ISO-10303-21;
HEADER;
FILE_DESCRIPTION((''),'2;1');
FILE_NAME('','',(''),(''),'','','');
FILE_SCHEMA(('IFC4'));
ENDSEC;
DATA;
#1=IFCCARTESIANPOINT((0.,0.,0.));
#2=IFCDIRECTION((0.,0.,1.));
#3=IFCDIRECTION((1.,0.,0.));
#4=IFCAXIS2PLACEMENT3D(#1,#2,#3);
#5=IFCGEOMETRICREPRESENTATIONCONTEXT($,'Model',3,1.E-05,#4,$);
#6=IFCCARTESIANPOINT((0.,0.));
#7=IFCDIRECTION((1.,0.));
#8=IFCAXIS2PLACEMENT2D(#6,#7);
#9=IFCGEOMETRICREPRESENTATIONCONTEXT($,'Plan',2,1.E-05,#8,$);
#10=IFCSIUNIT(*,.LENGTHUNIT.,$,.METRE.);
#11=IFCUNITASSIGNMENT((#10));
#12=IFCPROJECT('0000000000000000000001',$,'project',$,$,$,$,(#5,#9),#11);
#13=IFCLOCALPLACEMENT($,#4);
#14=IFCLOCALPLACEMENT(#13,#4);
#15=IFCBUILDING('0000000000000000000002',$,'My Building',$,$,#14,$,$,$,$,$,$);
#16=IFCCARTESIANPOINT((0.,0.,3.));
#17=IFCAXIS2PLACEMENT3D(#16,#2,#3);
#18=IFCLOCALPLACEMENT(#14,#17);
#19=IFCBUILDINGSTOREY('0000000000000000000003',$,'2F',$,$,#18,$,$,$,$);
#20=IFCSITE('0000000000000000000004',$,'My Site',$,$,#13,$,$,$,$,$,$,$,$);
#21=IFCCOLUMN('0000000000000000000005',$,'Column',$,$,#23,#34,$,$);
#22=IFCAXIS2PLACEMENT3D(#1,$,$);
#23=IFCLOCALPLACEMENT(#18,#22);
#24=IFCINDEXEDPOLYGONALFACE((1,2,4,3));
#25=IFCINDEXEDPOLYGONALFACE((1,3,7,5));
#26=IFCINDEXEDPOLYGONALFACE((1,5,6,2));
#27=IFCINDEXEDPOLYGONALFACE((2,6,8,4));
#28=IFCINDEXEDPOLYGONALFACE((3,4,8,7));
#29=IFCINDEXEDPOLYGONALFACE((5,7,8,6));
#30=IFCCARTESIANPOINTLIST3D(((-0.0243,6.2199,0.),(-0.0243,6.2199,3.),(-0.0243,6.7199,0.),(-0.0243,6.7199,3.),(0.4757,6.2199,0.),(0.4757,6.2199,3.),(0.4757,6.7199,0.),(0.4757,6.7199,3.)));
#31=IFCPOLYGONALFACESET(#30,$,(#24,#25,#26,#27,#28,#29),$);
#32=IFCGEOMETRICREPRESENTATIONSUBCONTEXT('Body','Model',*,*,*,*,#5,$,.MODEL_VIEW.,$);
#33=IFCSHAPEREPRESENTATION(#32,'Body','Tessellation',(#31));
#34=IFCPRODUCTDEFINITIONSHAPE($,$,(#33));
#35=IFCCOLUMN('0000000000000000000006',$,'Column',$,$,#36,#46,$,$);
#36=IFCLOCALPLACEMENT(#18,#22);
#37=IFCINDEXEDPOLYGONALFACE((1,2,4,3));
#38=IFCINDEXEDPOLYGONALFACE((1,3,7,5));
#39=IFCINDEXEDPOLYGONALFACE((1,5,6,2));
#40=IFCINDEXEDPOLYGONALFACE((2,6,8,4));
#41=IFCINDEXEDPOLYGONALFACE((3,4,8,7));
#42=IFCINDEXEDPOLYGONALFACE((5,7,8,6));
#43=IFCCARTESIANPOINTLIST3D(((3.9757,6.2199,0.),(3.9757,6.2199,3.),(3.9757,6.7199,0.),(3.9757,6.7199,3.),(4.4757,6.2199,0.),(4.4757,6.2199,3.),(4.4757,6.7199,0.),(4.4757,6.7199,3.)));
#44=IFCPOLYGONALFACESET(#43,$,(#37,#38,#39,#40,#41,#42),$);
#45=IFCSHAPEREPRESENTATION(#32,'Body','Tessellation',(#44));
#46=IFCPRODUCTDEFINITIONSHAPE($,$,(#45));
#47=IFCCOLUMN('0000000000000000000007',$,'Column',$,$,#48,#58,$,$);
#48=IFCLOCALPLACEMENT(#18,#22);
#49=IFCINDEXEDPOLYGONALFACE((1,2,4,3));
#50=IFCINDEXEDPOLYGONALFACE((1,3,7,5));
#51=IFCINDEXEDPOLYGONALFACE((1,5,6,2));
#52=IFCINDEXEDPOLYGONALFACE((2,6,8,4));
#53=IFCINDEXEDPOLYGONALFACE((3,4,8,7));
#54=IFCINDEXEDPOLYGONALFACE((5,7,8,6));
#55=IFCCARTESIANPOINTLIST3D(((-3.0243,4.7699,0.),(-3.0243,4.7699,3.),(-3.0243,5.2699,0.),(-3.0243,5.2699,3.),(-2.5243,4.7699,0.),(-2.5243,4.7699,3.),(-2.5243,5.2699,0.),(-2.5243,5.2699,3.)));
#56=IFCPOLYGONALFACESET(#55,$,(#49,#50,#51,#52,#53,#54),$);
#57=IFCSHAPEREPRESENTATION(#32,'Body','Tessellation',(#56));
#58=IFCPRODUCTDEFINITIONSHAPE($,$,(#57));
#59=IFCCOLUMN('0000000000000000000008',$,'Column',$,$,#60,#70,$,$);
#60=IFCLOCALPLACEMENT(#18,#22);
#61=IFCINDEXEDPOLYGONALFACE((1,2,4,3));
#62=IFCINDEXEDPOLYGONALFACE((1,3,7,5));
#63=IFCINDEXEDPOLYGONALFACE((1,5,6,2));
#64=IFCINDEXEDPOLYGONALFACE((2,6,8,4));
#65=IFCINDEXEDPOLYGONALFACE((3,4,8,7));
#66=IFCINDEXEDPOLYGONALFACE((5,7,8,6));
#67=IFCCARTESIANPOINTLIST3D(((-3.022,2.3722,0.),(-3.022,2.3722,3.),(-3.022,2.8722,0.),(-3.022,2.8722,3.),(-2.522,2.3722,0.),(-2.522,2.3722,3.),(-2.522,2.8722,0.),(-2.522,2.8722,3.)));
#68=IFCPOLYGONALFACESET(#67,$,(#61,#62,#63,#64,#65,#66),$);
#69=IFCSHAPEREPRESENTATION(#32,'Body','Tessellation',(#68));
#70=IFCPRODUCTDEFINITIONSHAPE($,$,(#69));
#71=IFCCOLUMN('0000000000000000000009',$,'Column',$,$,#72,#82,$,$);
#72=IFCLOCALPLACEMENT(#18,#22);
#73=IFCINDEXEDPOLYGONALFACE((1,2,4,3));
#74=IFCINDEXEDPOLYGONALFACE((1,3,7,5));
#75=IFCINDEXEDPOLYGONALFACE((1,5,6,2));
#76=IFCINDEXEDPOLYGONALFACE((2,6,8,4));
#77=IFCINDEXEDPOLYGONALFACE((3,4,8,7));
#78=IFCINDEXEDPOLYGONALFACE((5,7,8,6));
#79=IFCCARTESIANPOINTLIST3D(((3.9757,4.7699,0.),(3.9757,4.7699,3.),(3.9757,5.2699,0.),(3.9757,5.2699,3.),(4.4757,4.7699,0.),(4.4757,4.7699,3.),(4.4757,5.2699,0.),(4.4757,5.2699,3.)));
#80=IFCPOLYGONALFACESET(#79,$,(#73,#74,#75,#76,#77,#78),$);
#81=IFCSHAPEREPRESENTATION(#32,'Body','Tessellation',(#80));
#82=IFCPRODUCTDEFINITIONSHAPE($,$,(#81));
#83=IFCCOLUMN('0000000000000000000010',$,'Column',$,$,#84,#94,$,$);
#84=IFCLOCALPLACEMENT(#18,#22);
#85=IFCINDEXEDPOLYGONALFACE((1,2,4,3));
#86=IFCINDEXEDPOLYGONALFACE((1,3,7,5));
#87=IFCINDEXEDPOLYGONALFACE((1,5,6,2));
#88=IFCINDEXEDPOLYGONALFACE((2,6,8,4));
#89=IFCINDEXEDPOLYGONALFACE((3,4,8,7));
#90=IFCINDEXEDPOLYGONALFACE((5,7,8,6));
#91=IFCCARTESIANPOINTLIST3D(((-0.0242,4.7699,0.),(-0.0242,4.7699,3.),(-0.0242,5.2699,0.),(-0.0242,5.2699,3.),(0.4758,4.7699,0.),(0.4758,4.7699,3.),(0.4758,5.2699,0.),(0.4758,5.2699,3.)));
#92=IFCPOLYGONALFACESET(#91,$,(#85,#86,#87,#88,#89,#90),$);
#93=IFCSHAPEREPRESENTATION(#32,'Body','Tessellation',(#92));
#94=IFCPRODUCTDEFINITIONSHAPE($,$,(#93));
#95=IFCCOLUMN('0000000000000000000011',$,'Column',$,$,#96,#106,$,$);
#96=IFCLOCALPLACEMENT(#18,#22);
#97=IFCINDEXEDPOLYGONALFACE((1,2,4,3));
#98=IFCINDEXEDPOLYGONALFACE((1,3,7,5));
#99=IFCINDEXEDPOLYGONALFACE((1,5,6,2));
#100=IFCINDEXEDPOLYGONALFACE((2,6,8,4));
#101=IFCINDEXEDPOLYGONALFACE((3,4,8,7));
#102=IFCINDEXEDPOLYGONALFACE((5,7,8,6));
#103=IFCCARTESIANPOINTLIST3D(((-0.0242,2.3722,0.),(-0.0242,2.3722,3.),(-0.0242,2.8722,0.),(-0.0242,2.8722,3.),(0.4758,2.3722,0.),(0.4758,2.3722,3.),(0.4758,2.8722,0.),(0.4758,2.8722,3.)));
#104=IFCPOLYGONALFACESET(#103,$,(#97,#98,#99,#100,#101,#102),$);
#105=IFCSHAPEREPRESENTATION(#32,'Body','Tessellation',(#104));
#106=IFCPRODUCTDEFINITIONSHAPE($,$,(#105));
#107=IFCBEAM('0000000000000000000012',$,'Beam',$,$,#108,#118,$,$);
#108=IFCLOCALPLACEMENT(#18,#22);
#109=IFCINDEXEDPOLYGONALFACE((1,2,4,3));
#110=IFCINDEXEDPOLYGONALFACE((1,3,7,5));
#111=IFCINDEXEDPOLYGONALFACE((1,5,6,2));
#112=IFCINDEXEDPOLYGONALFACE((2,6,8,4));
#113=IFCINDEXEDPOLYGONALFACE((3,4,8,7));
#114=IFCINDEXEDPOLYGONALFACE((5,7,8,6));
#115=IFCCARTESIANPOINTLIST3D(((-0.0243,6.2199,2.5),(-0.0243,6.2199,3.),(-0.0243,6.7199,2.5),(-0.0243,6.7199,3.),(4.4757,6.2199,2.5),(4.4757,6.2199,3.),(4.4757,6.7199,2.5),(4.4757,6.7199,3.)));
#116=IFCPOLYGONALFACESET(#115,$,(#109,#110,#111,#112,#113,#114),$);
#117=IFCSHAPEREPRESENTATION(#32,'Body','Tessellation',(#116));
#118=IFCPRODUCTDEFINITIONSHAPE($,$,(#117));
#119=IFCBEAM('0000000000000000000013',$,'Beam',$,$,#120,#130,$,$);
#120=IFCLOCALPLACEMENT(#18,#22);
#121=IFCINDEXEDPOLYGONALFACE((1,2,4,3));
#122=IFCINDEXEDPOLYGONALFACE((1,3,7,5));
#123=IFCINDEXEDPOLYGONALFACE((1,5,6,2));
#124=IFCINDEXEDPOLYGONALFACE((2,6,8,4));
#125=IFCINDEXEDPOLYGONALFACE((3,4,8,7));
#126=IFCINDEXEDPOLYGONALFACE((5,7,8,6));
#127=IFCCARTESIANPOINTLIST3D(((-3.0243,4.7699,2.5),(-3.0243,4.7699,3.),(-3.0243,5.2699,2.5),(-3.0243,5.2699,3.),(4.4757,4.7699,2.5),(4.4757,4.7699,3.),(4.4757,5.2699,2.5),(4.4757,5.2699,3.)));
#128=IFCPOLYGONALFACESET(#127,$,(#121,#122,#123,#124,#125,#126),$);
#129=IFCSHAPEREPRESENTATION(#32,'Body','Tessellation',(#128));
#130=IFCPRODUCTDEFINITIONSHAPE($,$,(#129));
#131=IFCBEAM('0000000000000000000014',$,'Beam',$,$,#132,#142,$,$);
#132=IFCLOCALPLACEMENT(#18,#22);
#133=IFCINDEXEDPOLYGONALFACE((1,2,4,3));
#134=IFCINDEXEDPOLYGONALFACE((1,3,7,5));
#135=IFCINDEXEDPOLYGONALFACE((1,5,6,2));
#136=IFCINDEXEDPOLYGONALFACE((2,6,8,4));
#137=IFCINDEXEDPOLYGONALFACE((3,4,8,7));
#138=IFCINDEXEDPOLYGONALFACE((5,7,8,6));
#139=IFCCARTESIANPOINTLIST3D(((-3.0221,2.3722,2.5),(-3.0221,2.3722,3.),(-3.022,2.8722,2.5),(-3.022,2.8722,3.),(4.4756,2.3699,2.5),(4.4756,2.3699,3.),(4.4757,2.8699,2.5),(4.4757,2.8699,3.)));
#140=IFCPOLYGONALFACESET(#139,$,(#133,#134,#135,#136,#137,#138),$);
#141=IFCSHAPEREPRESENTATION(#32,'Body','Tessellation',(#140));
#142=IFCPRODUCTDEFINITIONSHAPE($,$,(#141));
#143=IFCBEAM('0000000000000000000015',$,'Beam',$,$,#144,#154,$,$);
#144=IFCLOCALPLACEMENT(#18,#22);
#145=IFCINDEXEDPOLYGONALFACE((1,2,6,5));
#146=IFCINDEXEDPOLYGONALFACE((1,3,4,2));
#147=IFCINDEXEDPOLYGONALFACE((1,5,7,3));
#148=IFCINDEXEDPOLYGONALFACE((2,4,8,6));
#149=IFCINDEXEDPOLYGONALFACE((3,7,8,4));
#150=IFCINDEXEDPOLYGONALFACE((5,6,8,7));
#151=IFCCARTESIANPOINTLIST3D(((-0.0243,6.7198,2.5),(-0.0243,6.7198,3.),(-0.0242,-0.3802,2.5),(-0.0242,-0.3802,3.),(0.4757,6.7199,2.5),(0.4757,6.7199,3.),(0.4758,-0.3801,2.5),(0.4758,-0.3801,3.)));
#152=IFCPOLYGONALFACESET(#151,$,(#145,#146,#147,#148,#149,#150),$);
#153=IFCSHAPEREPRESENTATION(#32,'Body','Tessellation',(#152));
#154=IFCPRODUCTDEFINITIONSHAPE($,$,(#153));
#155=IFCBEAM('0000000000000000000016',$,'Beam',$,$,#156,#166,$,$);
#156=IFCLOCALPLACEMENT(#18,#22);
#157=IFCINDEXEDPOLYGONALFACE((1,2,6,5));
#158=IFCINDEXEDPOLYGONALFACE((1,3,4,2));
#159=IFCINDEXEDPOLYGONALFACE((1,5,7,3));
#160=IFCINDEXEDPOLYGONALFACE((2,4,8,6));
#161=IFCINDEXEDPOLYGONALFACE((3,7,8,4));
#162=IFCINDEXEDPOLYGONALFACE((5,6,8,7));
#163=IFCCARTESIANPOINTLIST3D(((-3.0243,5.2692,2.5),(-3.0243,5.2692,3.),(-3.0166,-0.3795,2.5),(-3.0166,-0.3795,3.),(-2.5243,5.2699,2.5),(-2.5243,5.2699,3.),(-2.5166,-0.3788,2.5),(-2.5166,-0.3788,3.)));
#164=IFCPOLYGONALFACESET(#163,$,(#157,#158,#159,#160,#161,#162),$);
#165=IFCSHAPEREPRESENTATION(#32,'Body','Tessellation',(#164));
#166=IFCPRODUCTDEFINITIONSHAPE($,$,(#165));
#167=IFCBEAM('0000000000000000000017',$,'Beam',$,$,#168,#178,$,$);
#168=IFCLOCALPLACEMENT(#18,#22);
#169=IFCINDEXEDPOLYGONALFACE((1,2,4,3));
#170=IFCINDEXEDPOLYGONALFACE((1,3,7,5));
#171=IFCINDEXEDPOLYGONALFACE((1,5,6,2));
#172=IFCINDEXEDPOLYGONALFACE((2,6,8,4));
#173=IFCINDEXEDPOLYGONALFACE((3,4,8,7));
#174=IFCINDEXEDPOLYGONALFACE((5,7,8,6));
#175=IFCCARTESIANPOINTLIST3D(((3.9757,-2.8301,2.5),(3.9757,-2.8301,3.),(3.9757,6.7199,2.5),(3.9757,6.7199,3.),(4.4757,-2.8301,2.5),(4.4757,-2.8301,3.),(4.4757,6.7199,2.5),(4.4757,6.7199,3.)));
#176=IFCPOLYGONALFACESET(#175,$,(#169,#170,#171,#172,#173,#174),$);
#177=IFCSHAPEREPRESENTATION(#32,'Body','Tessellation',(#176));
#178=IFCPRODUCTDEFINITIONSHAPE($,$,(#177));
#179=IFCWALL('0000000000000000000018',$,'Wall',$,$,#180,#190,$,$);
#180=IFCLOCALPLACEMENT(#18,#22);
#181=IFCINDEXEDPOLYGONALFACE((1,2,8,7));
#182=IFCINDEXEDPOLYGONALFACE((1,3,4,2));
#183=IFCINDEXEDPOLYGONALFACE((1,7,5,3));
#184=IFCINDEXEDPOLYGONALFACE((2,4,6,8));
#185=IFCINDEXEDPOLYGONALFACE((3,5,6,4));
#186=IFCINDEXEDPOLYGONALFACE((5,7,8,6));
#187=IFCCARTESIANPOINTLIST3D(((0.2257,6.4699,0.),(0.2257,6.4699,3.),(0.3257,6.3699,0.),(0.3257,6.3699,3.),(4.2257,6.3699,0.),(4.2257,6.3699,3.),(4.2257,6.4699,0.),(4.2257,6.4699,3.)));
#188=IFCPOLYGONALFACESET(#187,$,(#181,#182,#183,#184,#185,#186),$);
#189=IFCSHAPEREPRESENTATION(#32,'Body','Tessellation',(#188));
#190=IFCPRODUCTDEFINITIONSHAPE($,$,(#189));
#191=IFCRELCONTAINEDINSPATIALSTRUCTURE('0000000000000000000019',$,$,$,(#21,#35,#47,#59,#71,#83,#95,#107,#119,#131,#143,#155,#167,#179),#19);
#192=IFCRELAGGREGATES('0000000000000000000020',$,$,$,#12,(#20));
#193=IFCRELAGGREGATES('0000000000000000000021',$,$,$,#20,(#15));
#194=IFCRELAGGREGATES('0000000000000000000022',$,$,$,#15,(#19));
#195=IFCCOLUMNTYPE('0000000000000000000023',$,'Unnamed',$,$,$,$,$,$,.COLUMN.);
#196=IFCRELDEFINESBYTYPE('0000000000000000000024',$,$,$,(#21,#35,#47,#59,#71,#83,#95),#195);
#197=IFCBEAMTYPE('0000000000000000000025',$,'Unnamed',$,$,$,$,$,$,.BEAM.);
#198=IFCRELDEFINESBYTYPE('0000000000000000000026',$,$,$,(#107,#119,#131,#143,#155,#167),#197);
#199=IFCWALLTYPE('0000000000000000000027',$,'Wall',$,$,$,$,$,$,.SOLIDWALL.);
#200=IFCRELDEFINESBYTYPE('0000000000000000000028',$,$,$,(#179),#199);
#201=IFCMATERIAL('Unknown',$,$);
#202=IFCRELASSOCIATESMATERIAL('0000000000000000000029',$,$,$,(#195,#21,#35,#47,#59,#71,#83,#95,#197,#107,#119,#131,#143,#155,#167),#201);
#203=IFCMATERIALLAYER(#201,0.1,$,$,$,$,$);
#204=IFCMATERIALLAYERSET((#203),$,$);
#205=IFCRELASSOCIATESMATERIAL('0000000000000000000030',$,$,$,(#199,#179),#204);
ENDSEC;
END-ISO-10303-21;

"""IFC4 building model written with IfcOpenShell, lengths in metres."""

from ifc_helpers import new_model, si_unit, frame, origin_with_axes, origin_2d_with_axis, place, context, subcontext, project, spatial, line, indexed_curve, rectangle, outline, extrude, material, layer, layer_set, layer_usage, material_profile, profile_set, profile_usage, type_object, element, save


model = new_model("IFC4")

# Units and contexts
model_context = context("Model", 3, precision=1e-05, world=origin_with_axes())
plan_context = context("Plan", 2, precision=1e-05, world=origin_2d_with_axis())
body_context_1 = subcontext(model_context, "Body", "Model", "MODEL_VIEW")
ifc_project = project(units=[si_unit("LENGTHUNIT", "METRE")], contexts=[model_context, plan_context])

# Site, building, storey
site_placement = place(None, origin_with_axes())
site = spatial("IfcSite", under=ifc_project, at=site_placement, Name="My Site")
building_placement = place(site_placement, origin_with_axes())
building = spatial("IfcBuilding", under=site, at=building_placement, Name="My Building")
storey_placement = place(building_placement, frame((0.0, 0.0, 3.0), z_axis=(0.0, 0.0, 1.0), x_axis=(1.0, 0.0, 0.0)))
storey = spatial("IfcBuildingStorey", under=building, at=storey_placement, Name="2F")

# Columns
ifc_material = material(Name="Unknown")
ifc_material_profile_1 = material_profile(ifc_material, rectangle(XDim=0.5, YDim=0.5))
ifc_profile_set_1 = profile_set([ifc_material_profile_1])
ifc_profile_usage_1 = profile_usage(ifc_profile_set_1, cardinal=5)
column_type = type_object("IfcColumnType", Name="Unnamed", PredefinedType="COLUMN", material=ifc_profile_set_1)
column_1_placement = place(storey_placement, frame((0.2257, 6.4699, 0.0), z_axis=(0.0, 0.0, 1.0), x_axis=(1.0, 0.0, 0.0)))
element("IfcColumn", 1, at=column_1_placement, inside=storey, type_object=column_type, material=ifc_profile_usage_1, Name="Column", context=body_context_1, shape_type="SweptSolid", body=[
    extrude(rectangle(XDim=0.5, YDim=0.5), origin_with_axes(), (0.0, 0.0, 1.0), 3.0),
])
ifc_profile_usage_2 = profile_usage(ifc_profile_set_1, cardinal=5)
column_2_placement = place(storey_placement, frame((4.2257, 6.4699, 0.0), z_axis=(0.0, 0.0, 1.0), x_axis=(1.0, 0.0, 0.0)))
element("IfcColumn", 2, at=column_2_placement, inside=storey, type_object=column_type, material=ifc_profile_usage_2, Name="Column", context=body_context_1, shape_type="SweptSolid", body=[
    extrude(rectangle(XDim=0.5, YDim=0.5), origin_with_axes(), (0.0, 0.0, 1.0), 3.0),
])
ifc_profile_usage_3 = profile_usage(ifc_profile_set_1, cardinal=5)
column_3_placement = place(storey_placement, frame((-2.7743, 5.0199, 0.0), z_axis=(0.0, 0.0, 1.0), x_axis=(1.0, 0.0, 0.0)))
element("IfcColumn", 3, at=column_3_placement, inside=storey, type_object=column_type, material=ifc_profile_usage_3, Name="Column", context=body_context_1, shape_type="SweptSolid", body=[
    extrude(rectangle(XDim=0.5, YDim=0.5), origin_with_axes(), (0.0, 0.0, 1.0), 3.0),
])
ifc_profile_usage_4 = profile_usage(ifc_profile_set_1, cardinal=5)
column_4_placement = place(storey_placement, frame((-2.772, 2.6222, 0.0), z_axis=(0.0, 0.0, 1.0), x_axis=(1.0, 0.0, 0.0)))
element("IfcColumn", 4, at=column_4_placement, inside=storey, type_object=column_type, material=ifc_profile_usage_4, Name="Column", context=body_context_1, shape_type="SweptSolid", body=[
    extrude(rectangle(XDim=0.5, YDim=0.5), origin_with_axes(), (0.0, 0.0, 1.0), 3.0),
])
ifc_profile_usage_5 = profile_usage(ifc_profile_set_1, cardinal=5)
column_5_placement = place(storey_placement, frame((4.2257, 5.0199, 0.0), z_axis=(0.0, 0.0, 1.0), x_axis=(1.0, 0.0, 0.0)))
element("IfcColumn", 5, at=column_5_placement, inside=storey, type_object=column_type, material=ifc_profile_usage_5, Name="Column", context=body_context_1, shape_type="SweptSolid", body=[
    extrude(rectangle(XDim=0.5, YDim=0.5), origin_with_axes(), (0.0, 0.0, 1.0), 3.0),
])
ifc_profile_usage_6 = profile_usage(ifc_profile_set_1, cardinal=5)
column_6_placement = place(storey_placement, frame((0.2258, 5.0199, 0.0), z_axis=(0.0, 0.0, 1.0), x_axis=(1.0, 0.0, 0.0)))
element("IfcColumn", 6, at=column_6_placement, inside=storey, type_object=column_type, material=ifc_profile_usage_6, Name="Column", context=body_context_1, shape_type="SweptSolid", body=[
    extrude(rectangle(XDim=0.5, YDim=0.5), origin_with_axes(), (0.0, 0.0, 1.0), 3.0),
])
ifc_profile_usage_7 = profile_usage(ifc_profile_set_1, cardinal=5)
column_7_placement = place(storey_placement, frame((0.2258, 2.6222, 0.0), z_axis=(0.0, 0.0, 1.0), x_axis=(1.0, 0.0, 0.0)))
element("IfcColumn", 7, at=column_7_placement, inside=storey, type_object=column_type, material=ifc_profile_usage_7, Name="Column", context=body_context_1, shape_type="SweptSolid", body=[
    extrude(rectangle(XDim=0.5, YDim=0.5), origin_with_axes(), (0.0, 0.0, 1.0), 3.0),
])

# Beams
ifc_material_profile_2 = material_profile(ifc_material, rectangle(XDim=0.5, YDim=0.5))
ifc_profile_set_2 = profile_set([ifc_material_profile_2])
ifc_profile_usage_8 = profile_usage(ifc_profile_set_2, cardinal=7)
beam_type = type_object("IfcBeamType", Name="Unnamed", PredefinedType="BEAM", material=ifc_profile_set_2)
beam_1_placement = place(storey_placement, frame((-0.0243, 6.7199, 3.0), z_axis=(1.0, 0.0, 0.0), x_axis=(0.0, 1.0, 0.0)))
element("IfcBeam", 8, at=beam_1_placement, inside=storey, type_object=beam_type, material=ifc_profile_usage_8, Name="Beam", context=body_context_1, shape_type="SweptSolid", body=[
    extrude(rectangle(XDim=0.5, YDim=0.5), frame((-0.25, -0.25, 0.0), z_axis=(0.0, 0.0, 1.0), x_axis=(1.0, 0.0, 0.0)), (0.0, 0.0, 1.0), 4.5),
])
ifc_profile_usage_9 = profile_usage(ifc_profile_set_2, cardinal=7)
beam_2_placement = place(storey_placement, frame((-3.0243, 5.2699, 3.0), z_axis=(1.0, -0.000001, 0.000001), x_axis=(0.000001, 1.0, 0.0)))
element("IfcBeam", 9, at=beam_2_placement, inside=storey, type_object=beam_type, material=ifc_profile_usage_9, Name="Beam", context=body_context_1, shape_type="SweptSolid", body=[
    extrude(rectangle(XDim=0.5, YDim=0.5), frame((-0.25, -0.25, 0.0), z_axis=(0.0, 0.0, 1.0), x_axis=(1.0, 0.0, 0.0)), (0.0, 0.0, 1.0), 7.5),
])
ifc_profile_usage_10 = profile_usage(ifc_profile_set_2, cardinal=7)
beam_3_placement = place(storey_placement, frame((-3.022, 2.8722, 3.0), z_axis=(1.0, -0.000316, 0.0), x_axis=(0.000316, 1.0, 0.0)))
element("IfcBeam", 10, at=beam_3_placement, inside=storey, type_object=beam_type, material=ifc_profile_usage_10, Name="Beam", context=body_context_1, shape_type="SweptSolid", body=[
    extrude(rectangle(XDim=0.5, YDim=0.5), frame((-0.25, -0.25, 0.0), z_axis=(0.0, 0.0, 1.0), x_axis=(1.0, 0.0, 0.0)), (0.0, 0.0, 1.0), 7.4977),
])
ifc_profile_usage_11 = profile_usage(ifc_profile_set_2, cardinal=7)
beam_4_placement = place(storey_placement, frame((0.4757, 6.7199, 3.0), z_axis=(0.000014, -1.0, 0.0), x_axis=(1.0, 0.000014, 0.0)))
element("IfcBeam", 11, at=beam_4_placement, inside=storey, type_object=beam_type, material=ifc_profile_usage_11, Name="Beam", context=body_context_1, shape_type="SweptSolid", body=[
    extrude(rectangle(XDim=0.5, YDim=0.5), frame((-0.25, -0.25, 0.0), z_axis=(0.0, 0.0, 1.0), x_axis=(1.0, 0.0, 0.0)), (0.0, 0.0, 1.0), 7.1),
])
ifc_profile_usage_12 = profile_usage(ifc_profile_set_2, cardinal=7)
beam_5_placement = place(storey_placement, frame((-2.5243, 5.2699, 3.0), z_axis=(0.001352, -0.999999, 0.0), x_axis=(0.999999, 0.001352, 0.0)))
element("IfcBeam", 12, at=beam_5_placement, inside=storey, type_object=beam_type, material=ifc_profile_usage_12, Name="Beam", context=body_context_1, shape_type="SweptSolid", body=[
    extrude(rectangle(XDim=0.5, YDim=0.5), frame((-0.25, -0.25, 0.0), z_axis=(0.0, 0.0, 1.0), x_axis=(1.0, 0.0, 0.0)), (0.0, 0.0, 1.0), 5.6487),
])
ifc_profile_usage_13 = profile_usage(ifc_profile_set_2, cardinal=7)
beam_6_placement = place(storey_placement, frame((4.4757, 6.7199, 3.0), z_axis=(0.0, -1.0, 0.0), x_axis=(1.0, 0.0, 0.0)))
element("IfcBeam", 13, at=beam_6_placement, inside=storey, type_object=beam_type, material=ifc_profile_usage_13, Name="Beam", context=body_context_1, shape_type="SweptSolid", body=[
    extrude(rectangle(XDim=0.5, YDim=0.5), frame((-0.25, -0.25, 0.0), z_axis=(0.0, 0.0, 1.0), x_axis=(1.0, 0.0, 0.0)), (0.0, 0.0, 1.0), 9.55),
])

# Wall
ifc_layer = layer(ifc_material, 0.1)
ifc_layer_set = layer_set([ifc_layer])
ifc_layer_usage_1 = layer_usage(ifc_layer_set, "AXIS2", "POSITIVE", 0.0)
wall_type = type_object("IfcWallType", Name="Wall", PredefinedType="SOLIDWALL", material=ifc_layer_set)
wall_1_placement = place(storey_placement, frame((4.2257, 6.4699, 0.0), z_axis=(0.0, 0.0, 1.0), x_axis=(-1.0, 0.0, 0.0)))
element("IfcWall", 14, at=wall_1_placement, inside=storey, type_object=wall_type, material=ifc_layer_usage_1, Name="Wall", context=body_context_1, shape_type="SweptSolid", body=[
    extrude(outline(indexed_curve([(0.0, 0.0), (0.0, 0.1), (3.9, 0.1), (4.0, 0.0)], segments=[line(1, 2, 3, 4, 1)])), origin_with_axes(), (0.0, 0.0, 1.0), 3.0),
])

save(model, "model.ifc")
